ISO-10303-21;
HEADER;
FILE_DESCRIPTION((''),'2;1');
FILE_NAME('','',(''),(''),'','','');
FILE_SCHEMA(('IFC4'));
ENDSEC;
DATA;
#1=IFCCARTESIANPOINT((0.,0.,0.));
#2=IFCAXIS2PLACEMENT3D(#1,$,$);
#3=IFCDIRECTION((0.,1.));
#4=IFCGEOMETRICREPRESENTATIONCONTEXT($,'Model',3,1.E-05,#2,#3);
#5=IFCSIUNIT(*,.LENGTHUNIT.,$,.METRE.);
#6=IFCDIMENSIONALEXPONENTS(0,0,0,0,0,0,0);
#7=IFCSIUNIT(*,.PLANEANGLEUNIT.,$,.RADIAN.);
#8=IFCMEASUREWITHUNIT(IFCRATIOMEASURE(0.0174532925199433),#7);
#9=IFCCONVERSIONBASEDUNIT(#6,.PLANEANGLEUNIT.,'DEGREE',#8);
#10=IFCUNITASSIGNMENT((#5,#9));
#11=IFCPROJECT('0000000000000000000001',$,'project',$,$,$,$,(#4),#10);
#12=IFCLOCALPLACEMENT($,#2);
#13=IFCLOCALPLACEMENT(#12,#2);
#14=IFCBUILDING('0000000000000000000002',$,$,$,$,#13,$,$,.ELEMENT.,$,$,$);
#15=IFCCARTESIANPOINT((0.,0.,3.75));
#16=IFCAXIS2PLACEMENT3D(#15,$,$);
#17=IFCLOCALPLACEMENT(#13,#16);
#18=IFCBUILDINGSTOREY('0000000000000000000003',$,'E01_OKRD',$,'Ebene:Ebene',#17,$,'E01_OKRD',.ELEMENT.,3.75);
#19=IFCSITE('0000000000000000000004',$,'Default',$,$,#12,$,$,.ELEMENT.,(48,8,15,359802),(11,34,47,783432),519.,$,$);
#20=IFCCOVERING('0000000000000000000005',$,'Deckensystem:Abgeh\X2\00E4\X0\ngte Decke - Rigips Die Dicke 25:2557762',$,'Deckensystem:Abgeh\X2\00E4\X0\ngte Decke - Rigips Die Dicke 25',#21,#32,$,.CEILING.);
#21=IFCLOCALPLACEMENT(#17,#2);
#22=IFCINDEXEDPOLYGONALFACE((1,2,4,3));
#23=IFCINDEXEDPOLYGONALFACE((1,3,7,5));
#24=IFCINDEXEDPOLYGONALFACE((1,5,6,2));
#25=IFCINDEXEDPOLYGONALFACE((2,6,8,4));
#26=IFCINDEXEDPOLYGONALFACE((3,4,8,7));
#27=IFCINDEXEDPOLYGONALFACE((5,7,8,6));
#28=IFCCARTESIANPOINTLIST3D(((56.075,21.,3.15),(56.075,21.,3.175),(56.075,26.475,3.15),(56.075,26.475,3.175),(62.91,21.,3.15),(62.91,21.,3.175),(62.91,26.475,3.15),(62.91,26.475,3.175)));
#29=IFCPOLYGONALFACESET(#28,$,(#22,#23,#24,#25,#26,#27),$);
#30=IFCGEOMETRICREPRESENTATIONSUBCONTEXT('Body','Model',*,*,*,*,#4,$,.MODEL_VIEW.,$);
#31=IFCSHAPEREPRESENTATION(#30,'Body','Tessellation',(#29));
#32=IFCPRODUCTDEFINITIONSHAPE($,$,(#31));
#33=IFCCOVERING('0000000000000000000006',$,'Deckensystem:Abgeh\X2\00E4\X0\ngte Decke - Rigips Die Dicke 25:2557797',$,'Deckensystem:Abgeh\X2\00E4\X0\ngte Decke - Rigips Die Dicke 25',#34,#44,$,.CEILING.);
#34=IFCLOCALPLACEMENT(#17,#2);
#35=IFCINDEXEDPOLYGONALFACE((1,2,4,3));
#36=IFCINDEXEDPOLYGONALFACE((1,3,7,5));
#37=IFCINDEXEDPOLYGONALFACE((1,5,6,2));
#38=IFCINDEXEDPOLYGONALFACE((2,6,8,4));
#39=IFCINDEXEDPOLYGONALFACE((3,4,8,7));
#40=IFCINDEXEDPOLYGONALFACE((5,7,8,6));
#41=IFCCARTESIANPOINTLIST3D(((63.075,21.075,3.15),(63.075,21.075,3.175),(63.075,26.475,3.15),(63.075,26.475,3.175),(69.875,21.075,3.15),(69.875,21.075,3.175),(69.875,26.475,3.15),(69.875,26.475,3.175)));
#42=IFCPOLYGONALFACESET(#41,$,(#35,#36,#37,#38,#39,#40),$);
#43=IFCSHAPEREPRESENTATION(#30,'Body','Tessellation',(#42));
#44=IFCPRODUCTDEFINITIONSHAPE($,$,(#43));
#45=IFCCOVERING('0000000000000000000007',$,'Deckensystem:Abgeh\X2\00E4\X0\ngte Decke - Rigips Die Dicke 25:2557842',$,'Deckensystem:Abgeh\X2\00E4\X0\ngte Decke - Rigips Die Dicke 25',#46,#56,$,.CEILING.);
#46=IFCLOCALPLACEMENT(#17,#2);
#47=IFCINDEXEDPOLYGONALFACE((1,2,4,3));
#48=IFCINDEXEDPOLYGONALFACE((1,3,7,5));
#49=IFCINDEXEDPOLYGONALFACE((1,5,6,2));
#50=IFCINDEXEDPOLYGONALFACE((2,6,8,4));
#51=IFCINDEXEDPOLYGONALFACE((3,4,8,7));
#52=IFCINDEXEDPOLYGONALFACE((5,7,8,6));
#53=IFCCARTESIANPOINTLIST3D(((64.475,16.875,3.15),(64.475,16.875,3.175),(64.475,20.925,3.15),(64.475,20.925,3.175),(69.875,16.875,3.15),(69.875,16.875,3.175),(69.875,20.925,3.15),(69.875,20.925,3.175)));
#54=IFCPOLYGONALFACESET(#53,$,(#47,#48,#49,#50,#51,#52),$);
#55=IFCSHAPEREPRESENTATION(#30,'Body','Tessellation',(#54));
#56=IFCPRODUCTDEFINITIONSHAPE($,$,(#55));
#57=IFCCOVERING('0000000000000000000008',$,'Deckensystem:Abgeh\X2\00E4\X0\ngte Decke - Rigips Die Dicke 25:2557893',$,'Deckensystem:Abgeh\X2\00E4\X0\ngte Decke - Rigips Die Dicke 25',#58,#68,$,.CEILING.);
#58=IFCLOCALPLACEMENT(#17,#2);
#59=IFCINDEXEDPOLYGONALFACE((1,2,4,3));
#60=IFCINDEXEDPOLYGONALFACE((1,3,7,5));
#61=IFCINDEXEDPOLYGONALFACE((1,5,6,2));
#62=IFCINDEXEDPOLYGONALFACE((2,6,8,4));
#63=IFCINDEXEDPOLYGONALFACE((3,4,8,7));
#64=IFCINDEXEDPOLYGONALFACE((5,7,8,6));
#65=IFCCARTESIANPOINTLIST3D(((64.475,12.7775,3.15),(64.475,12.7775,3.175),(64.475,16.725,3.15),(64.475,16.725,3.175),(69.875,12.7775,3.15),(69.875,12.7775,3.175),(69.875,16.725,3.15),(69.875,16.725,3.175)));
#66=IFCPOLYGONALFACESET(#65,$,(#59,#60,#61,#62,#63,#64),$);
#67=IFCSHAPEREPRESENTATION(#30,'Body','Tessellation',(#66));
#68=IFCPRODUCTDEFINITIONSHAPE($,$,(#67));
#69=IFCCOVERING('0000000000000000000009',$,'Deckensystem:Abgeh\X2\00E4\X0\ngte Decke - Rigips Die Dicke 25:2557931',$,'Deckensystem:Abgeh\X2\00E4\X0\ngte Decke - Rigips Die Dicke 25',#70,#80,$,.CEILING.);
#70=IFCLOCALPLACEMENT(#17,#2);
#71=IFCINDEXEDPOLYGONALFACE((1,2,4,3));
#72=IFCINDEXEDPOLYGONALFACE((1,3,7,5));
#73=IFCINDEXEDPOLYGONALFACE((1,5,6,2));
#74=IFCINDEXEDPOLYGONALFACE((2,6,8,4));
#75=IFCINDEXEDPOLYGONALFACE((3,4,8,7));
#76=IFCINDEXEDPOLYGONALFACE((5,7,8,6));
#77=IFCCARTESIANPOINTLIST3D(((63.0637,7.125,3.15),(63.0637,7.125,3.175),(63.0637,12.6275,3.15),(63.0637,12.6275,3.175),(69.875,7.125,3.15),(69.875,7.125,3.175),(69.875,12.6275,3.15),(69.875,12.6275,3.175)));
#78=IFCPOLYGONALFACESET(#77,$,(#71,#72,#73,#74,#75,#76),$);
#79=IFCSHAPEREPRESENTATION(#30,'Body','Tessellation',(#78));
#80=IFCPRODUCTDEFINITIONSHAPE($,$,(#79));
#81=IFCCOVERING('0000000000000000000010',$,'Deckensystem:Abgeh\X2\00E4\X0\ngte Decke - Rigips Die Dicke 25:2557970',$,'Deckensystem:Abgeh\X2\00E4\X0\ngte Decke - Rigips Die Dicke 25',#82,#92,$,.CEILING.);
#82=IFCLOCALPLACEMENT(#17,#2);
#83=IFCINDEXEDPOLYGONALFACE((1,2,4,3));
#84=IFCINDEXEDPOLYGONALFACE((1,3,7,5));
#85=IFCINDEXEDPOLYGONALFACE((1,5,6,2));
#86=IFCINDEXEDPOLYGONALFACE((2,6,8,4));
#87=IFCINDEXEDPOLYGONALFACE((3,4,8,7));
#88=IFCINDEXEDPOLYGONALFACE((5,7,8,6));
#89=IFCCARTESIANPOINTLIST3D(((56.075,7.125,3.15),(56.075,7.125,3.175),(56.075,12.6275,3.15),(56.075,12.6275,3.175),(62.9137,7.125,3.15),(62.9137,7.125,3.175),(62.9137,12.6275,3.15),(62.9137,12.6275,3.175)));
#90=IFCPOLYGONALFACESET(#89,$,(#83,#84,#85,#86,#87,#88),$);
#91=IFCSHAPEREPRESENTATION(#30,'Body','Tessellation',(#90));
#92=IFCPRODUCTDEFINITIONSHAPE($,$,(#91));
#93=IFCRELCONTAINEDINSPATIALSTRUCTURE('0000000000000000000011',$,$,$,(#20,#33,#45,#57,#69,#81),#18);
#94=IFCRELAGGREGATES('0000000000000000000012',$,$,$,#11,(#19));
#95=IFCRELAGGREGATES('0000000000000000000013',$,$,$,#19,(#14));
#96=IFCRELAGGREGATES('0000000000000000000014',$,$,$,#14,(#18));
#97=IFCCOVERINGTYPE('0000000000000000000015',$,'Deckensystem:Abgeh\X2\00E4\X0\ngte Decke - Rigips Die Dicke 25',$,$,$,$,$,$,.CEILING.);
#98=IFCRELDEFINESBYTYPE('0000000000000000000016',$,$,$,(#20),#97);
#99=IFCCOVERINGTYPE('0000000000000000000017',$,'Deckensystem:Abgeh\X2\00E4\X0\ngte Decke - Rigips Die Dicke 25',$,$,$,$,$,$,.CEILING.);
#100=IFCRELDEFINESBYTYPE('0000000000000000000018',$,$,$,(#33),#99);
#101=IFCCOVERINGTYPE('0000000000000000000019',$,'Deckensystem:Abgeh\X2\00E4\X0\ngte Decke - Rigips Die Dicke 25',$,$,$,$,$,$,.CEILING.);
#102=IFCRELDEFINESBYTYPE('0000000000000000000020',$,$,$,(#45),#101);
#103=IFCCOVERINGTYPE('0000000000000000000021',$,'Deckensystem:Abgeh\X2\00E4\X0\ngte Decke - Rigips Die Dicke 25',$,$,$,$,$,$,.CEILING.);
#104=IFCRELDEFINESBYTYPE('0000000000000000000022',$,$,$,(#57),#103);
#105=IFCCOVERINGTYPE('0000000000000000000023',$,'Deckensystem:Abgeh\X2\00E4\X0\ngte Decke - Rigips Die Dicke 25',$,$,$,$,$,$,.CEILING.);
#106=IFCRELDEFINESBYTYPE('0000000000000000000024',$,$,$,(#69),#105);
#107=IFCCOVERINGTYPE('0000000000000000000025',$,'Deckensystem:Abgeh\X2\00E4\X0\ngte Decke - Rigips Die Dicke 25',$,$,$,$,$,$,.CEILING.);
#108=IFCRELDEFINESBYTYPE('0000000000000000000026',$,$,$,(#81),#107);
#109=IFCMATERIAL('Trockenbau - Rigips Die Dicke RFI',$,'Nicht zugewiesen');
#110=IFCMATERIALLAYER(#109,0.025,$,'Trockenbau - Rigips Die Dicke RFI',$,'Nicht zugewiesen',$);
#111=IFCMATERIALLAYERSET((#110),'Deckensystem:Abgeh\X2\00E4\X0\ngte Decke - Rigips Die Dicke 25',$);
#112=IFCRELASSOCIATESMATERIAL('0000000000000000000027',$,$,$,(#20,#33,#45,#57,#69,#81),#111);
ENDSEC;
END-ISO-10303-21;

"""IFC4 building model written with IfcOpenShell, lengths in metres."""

from ifc_helpers import new_model, entity, si_unit, converted_unit, direction, frame, frame_2d, origin, origin_2d_with_axis, place, context, subcontext, project, spatial, rectangle, extrude, material, layer, layer_set, layer_usage, type_object, element, save


model = new_model("IFC4")

# Units and contexts
model_context = context("Model", 3, precision=1e-05, world=origin(), true_north=direction((0.0, 1.0)))
body_context = subcontext(model_context, "Body", "Model", "MODEL_VIEW")
ifc_project = project(units=[si_unit("LENGTHUNIT", "METRE"), converted_unit("PLANEANGLEUNIT", "DEGREE", entity("IfcRatioMeasure", 0.0174532925199433), si_unit("PLANEANGLEUNIT", "RADIAN"), dimensions=[0, 0, 0, 0, 0, 0, 0])], contexts=[model_context])

# Site, building, storey
site_placement = place(None, frame((0.0, 0.0, 0.0)))
site = spatial("IfcSite", under=ifc_project, at=site_placement, Name="Default", CompositionType="ELEMENT", RefLatitude=(48, 8, 15, 359802), RefLongitude=(11, 34, 47, 783432), RefElevation=519.0)
building_placement = place(site_placement, origin())
building = spatial("IfcBuilding", under=site, at=building_placement, CompositionType="ELEMENT")
storey_placement = place(building_placement, frame((0.0, 0.0, 3.75)))
storey = spatial("IfcBuildingStorey", under=building, at=storey_placement, Name="E01_OKRD", ObjectType="Ebene:Ebene", LongName="E01_OKRD", CompositionType="ELEMENT", Elevation=3.75)

# Coverings
ifc_material_1 = material(Name="Trockenbau - Rigips Die Dicke RFI", Category="Nicht zugewiesen")
ifc_layer_1 = layer(ifc_material_1, 0.025, Name="Trockenbau - Rigips Die Dicke RFI", Category="Nicht zugewiesen")
ifc_layer_set_1 = layer_set([ifc_layer_1], Name="Deckensystem:Abgehängte Decke - Rigips Die Dicke 25")
ifc_layer_usage_1 = layer_usage(ifc_layer_set_1, "AXIS3", "POSITIVE", 0.0)
covering_type_1 = type_object("IfcCoveringType", Name="Deckensystem:Abgehängte Decke - Rigips Die Dicke 25", PredefinedType="CEILING")
covering_1_placement = place(storey_placement, frame((56.075, 21.0, 3.15)))
element("IfcCovering", 1, at=covering_1_placement, inside=storey, type_object=covering_type_1, material=ifc_layer_usage_1, Name="Deckensystem:Abgehängte Decke - Rigips Die Dicke 25:2557762", ObjectType="Deckensystem:Abgehängte Decke - Rigips Die Dicke 25", PredefinedType="CEILING", context=body_context, shape_type="SweptSolid", body=[
    extrude(rectangle(XDim=6.835, YDim=5.475, at=frame_2d((0.0, 0.0), x_axis=(1.0, 0.0))), frame((3.4175, 2.7375, 0.0), z_axis=(0.0, 0.0, 1.0), x_axis=(-1.0, 0.0, 0.0)), (0.0, 0.0, 1.0), 0.025),
])
ifc_layer_usage_2 = layer_usage(ifc_layer_set_1, "AXIS3", "POSITIVE", 0.0)
covering_type_2 = type_object("IfcCoveringType", Name="Deckensystem:Abgehängte Decke - Rigips Die Dicke 25", PredefinedType="CEILING")
covering_2_placement = place(storey_placement, frame((63.075, 21.075, 3.15)))
element("IfcCovering", 2, at=covering_2_placement, inside=storey, type_object=covering_type_2, material=ifc_layer_usage_2, Name="Deckensystem:Abgehängte Decke - Rigips Die Dicke 25:2557797", ObjectType="Deckensystem:Abgehängte Decke - Rigips Die Dicke 25", PredefinedType="CEILING", context=body_context, shape_type="SweptSolid", body=[
    extrude(rectangle(XDim=6.8, YDim=5.4, at=frame_2d((0.0, 0.0), x_axis=(1.0, 0.0))), frame((3.4, 2.7, 0.0), z_axis=(0.0, 0.0, 1.0), x_axis=(-1.0, 0.0, 0.0)), (0.0, 0.0, 1.0), 0.025),
])
ifc_layer_usage_3 = layer_usage(ifc_layer_set_1, "AXIS3", "POSITIVE", 0.0)
covering_type_3 = type_object("IfcCoveringType", Name="Deckensystem:Abgehängte Decke - Rigips Die Dicke 25", PredefinedType="CEILING")
covering_3_placement = place(storey_placement, frame((64.475, 16.875, 3.15)))
element("IfcCovering", 3, at=covering_3_placement, inside=storey, type_object=covering_type_3, material=ifc_layer_usage_3, Name="Deckensystem:Abgehängte Decke - Rigips Die Dicke 25:2557842", ObjectType="Deckensystem:Abgehängte Decke - Rigips Die Dicke 25", PredefinedType="CEILING", context=body_context, shape_type="SweptSolid", body=[
    extrude(rectangle(XDim=5.4, YDim=4.05, at=frame_2d((0.0, 0.0), x_axis=(1.0, 0.0))), frame((2.7, 2.025, 0.0), z_axis=(0.0, 0.0, 1.0), x_axis=(-1.0, 0.0, 0.0)), (0.0, 0.0, 1.0), 0.025),
])
ifc_layer_usage_4 = layer_usage(ifc_layer_set_1, "AXIS3", "POSITIVE", 0.0)
covering_type_4 = type_object("IfcCoveringType", Name="Deckensystem:Abgehängte Decke - Rigips Die Dicke 25", PredefinedType="CEILING")
covering_4_placement = place(storey_placement, frame((64.475, 12.7775, 3.15)))
element("IfcCovering", 4, at=covering_4_placement, inside=storey, type_object=covering_type_4, material=ifc_layer_usage_4, Name="Deckensystem:Abgehängte Decke - Rigips Die Dicke 25:2557893", ObjectType="Deckensystem:Abgehängte Decke - Rigips Die Dicke 25", PredefinedType="CEILING", context=body_context, shape_type="SweptSolid", body=[
    extrude(rectangle(XDim=5.4, YDim=3.9475, at=frame_2d((0.0, 0.0), x_axis=(1.0, 0.0))), frame((2.7, 1.9737, 0.0), z_axis=(0.0, 0.0, 1.0), x_axis=(-1.0, 0.0, 0.0)), (0.0, 0.0, 1.0), 0.025),
])
ifc_layer_usage_5 = layer_usage(ifc_layer_set_1, "AXIS3", "POSITIVE", 0.0)
covering_type_5 = type_object("IfcCoveringType", Name="Deckensystem:Abgehängte Decke - Rigips Die Dicke 25", PredefinedType="CEILING")
covering_5_placement = place(storey_placement, frame((63.0637, 7.125, 3.15)))
element("IfcCovering", 5, at=covering_5_placement, inside=storey, type_object=covering_type_5, material=ifc_layer_usage_5, Name="Deckensystem:Abgehängte Decke - Rigips Die Dicke 25:2557931", ObjectType="Deckensystem:Abgehängte Decke - Rigips Die Dicke 25", PredefinedType="CEILING", context=body_context, shape_type="SweptSolid", body=[
    extrude(rectangle(XDim=6.8113, YDim=5.5025, at=origin_2d_with_axis()), frame((3.4056, 2.7512, 0.0), z_axis=(0.0, 0.0, 1.0), x_axis=(-1.0, 0.0, 0.0)), (0.0, 0.0, 1.0), 0.025),
])
ifc_layer_usage_6 = layer_usage(ifc_layer_set_1, "AXIS3", "POSITIVE", 0.0)
covering_type_6 = type_object("IfcCoveringType", Name="Deckensystem:Abgehängte Decke - Rigips Die Dicke 25", PredefinedType="CEILING")
covering_6_placement = place(storey_placement, frame((56.075, 7.125, 3.15)))
element("IfcCovering", 6, at=covering_6_placement, inside=storey, type_object=covering_type_6, material=ifc_layer_usage_6, Name="Deckensystem:Abgehängte Decke - Rigips Die Dicke 25:2557970", ObjectType="Deckensystem:Abgehängte Decke - Rigips Die Dicke 25", PredefinedType="CEILING", context=body_context, shape_type="SweptSolid", body=[
    extrude(rectangle(XDim=6.8388, YDim=5.5025, at=frame_2d((0.0, 0.0), x_axis=(1.0, 0.0))), frame((3.4194, 2.7512, 0.0), z_axis=(0.0, 0.0, 1.0), x_axis=(-1.0, 0.0, 0.0)), (0.0, 0.0, 1.0), 0.025),
])

save(model, "model.ifc")
